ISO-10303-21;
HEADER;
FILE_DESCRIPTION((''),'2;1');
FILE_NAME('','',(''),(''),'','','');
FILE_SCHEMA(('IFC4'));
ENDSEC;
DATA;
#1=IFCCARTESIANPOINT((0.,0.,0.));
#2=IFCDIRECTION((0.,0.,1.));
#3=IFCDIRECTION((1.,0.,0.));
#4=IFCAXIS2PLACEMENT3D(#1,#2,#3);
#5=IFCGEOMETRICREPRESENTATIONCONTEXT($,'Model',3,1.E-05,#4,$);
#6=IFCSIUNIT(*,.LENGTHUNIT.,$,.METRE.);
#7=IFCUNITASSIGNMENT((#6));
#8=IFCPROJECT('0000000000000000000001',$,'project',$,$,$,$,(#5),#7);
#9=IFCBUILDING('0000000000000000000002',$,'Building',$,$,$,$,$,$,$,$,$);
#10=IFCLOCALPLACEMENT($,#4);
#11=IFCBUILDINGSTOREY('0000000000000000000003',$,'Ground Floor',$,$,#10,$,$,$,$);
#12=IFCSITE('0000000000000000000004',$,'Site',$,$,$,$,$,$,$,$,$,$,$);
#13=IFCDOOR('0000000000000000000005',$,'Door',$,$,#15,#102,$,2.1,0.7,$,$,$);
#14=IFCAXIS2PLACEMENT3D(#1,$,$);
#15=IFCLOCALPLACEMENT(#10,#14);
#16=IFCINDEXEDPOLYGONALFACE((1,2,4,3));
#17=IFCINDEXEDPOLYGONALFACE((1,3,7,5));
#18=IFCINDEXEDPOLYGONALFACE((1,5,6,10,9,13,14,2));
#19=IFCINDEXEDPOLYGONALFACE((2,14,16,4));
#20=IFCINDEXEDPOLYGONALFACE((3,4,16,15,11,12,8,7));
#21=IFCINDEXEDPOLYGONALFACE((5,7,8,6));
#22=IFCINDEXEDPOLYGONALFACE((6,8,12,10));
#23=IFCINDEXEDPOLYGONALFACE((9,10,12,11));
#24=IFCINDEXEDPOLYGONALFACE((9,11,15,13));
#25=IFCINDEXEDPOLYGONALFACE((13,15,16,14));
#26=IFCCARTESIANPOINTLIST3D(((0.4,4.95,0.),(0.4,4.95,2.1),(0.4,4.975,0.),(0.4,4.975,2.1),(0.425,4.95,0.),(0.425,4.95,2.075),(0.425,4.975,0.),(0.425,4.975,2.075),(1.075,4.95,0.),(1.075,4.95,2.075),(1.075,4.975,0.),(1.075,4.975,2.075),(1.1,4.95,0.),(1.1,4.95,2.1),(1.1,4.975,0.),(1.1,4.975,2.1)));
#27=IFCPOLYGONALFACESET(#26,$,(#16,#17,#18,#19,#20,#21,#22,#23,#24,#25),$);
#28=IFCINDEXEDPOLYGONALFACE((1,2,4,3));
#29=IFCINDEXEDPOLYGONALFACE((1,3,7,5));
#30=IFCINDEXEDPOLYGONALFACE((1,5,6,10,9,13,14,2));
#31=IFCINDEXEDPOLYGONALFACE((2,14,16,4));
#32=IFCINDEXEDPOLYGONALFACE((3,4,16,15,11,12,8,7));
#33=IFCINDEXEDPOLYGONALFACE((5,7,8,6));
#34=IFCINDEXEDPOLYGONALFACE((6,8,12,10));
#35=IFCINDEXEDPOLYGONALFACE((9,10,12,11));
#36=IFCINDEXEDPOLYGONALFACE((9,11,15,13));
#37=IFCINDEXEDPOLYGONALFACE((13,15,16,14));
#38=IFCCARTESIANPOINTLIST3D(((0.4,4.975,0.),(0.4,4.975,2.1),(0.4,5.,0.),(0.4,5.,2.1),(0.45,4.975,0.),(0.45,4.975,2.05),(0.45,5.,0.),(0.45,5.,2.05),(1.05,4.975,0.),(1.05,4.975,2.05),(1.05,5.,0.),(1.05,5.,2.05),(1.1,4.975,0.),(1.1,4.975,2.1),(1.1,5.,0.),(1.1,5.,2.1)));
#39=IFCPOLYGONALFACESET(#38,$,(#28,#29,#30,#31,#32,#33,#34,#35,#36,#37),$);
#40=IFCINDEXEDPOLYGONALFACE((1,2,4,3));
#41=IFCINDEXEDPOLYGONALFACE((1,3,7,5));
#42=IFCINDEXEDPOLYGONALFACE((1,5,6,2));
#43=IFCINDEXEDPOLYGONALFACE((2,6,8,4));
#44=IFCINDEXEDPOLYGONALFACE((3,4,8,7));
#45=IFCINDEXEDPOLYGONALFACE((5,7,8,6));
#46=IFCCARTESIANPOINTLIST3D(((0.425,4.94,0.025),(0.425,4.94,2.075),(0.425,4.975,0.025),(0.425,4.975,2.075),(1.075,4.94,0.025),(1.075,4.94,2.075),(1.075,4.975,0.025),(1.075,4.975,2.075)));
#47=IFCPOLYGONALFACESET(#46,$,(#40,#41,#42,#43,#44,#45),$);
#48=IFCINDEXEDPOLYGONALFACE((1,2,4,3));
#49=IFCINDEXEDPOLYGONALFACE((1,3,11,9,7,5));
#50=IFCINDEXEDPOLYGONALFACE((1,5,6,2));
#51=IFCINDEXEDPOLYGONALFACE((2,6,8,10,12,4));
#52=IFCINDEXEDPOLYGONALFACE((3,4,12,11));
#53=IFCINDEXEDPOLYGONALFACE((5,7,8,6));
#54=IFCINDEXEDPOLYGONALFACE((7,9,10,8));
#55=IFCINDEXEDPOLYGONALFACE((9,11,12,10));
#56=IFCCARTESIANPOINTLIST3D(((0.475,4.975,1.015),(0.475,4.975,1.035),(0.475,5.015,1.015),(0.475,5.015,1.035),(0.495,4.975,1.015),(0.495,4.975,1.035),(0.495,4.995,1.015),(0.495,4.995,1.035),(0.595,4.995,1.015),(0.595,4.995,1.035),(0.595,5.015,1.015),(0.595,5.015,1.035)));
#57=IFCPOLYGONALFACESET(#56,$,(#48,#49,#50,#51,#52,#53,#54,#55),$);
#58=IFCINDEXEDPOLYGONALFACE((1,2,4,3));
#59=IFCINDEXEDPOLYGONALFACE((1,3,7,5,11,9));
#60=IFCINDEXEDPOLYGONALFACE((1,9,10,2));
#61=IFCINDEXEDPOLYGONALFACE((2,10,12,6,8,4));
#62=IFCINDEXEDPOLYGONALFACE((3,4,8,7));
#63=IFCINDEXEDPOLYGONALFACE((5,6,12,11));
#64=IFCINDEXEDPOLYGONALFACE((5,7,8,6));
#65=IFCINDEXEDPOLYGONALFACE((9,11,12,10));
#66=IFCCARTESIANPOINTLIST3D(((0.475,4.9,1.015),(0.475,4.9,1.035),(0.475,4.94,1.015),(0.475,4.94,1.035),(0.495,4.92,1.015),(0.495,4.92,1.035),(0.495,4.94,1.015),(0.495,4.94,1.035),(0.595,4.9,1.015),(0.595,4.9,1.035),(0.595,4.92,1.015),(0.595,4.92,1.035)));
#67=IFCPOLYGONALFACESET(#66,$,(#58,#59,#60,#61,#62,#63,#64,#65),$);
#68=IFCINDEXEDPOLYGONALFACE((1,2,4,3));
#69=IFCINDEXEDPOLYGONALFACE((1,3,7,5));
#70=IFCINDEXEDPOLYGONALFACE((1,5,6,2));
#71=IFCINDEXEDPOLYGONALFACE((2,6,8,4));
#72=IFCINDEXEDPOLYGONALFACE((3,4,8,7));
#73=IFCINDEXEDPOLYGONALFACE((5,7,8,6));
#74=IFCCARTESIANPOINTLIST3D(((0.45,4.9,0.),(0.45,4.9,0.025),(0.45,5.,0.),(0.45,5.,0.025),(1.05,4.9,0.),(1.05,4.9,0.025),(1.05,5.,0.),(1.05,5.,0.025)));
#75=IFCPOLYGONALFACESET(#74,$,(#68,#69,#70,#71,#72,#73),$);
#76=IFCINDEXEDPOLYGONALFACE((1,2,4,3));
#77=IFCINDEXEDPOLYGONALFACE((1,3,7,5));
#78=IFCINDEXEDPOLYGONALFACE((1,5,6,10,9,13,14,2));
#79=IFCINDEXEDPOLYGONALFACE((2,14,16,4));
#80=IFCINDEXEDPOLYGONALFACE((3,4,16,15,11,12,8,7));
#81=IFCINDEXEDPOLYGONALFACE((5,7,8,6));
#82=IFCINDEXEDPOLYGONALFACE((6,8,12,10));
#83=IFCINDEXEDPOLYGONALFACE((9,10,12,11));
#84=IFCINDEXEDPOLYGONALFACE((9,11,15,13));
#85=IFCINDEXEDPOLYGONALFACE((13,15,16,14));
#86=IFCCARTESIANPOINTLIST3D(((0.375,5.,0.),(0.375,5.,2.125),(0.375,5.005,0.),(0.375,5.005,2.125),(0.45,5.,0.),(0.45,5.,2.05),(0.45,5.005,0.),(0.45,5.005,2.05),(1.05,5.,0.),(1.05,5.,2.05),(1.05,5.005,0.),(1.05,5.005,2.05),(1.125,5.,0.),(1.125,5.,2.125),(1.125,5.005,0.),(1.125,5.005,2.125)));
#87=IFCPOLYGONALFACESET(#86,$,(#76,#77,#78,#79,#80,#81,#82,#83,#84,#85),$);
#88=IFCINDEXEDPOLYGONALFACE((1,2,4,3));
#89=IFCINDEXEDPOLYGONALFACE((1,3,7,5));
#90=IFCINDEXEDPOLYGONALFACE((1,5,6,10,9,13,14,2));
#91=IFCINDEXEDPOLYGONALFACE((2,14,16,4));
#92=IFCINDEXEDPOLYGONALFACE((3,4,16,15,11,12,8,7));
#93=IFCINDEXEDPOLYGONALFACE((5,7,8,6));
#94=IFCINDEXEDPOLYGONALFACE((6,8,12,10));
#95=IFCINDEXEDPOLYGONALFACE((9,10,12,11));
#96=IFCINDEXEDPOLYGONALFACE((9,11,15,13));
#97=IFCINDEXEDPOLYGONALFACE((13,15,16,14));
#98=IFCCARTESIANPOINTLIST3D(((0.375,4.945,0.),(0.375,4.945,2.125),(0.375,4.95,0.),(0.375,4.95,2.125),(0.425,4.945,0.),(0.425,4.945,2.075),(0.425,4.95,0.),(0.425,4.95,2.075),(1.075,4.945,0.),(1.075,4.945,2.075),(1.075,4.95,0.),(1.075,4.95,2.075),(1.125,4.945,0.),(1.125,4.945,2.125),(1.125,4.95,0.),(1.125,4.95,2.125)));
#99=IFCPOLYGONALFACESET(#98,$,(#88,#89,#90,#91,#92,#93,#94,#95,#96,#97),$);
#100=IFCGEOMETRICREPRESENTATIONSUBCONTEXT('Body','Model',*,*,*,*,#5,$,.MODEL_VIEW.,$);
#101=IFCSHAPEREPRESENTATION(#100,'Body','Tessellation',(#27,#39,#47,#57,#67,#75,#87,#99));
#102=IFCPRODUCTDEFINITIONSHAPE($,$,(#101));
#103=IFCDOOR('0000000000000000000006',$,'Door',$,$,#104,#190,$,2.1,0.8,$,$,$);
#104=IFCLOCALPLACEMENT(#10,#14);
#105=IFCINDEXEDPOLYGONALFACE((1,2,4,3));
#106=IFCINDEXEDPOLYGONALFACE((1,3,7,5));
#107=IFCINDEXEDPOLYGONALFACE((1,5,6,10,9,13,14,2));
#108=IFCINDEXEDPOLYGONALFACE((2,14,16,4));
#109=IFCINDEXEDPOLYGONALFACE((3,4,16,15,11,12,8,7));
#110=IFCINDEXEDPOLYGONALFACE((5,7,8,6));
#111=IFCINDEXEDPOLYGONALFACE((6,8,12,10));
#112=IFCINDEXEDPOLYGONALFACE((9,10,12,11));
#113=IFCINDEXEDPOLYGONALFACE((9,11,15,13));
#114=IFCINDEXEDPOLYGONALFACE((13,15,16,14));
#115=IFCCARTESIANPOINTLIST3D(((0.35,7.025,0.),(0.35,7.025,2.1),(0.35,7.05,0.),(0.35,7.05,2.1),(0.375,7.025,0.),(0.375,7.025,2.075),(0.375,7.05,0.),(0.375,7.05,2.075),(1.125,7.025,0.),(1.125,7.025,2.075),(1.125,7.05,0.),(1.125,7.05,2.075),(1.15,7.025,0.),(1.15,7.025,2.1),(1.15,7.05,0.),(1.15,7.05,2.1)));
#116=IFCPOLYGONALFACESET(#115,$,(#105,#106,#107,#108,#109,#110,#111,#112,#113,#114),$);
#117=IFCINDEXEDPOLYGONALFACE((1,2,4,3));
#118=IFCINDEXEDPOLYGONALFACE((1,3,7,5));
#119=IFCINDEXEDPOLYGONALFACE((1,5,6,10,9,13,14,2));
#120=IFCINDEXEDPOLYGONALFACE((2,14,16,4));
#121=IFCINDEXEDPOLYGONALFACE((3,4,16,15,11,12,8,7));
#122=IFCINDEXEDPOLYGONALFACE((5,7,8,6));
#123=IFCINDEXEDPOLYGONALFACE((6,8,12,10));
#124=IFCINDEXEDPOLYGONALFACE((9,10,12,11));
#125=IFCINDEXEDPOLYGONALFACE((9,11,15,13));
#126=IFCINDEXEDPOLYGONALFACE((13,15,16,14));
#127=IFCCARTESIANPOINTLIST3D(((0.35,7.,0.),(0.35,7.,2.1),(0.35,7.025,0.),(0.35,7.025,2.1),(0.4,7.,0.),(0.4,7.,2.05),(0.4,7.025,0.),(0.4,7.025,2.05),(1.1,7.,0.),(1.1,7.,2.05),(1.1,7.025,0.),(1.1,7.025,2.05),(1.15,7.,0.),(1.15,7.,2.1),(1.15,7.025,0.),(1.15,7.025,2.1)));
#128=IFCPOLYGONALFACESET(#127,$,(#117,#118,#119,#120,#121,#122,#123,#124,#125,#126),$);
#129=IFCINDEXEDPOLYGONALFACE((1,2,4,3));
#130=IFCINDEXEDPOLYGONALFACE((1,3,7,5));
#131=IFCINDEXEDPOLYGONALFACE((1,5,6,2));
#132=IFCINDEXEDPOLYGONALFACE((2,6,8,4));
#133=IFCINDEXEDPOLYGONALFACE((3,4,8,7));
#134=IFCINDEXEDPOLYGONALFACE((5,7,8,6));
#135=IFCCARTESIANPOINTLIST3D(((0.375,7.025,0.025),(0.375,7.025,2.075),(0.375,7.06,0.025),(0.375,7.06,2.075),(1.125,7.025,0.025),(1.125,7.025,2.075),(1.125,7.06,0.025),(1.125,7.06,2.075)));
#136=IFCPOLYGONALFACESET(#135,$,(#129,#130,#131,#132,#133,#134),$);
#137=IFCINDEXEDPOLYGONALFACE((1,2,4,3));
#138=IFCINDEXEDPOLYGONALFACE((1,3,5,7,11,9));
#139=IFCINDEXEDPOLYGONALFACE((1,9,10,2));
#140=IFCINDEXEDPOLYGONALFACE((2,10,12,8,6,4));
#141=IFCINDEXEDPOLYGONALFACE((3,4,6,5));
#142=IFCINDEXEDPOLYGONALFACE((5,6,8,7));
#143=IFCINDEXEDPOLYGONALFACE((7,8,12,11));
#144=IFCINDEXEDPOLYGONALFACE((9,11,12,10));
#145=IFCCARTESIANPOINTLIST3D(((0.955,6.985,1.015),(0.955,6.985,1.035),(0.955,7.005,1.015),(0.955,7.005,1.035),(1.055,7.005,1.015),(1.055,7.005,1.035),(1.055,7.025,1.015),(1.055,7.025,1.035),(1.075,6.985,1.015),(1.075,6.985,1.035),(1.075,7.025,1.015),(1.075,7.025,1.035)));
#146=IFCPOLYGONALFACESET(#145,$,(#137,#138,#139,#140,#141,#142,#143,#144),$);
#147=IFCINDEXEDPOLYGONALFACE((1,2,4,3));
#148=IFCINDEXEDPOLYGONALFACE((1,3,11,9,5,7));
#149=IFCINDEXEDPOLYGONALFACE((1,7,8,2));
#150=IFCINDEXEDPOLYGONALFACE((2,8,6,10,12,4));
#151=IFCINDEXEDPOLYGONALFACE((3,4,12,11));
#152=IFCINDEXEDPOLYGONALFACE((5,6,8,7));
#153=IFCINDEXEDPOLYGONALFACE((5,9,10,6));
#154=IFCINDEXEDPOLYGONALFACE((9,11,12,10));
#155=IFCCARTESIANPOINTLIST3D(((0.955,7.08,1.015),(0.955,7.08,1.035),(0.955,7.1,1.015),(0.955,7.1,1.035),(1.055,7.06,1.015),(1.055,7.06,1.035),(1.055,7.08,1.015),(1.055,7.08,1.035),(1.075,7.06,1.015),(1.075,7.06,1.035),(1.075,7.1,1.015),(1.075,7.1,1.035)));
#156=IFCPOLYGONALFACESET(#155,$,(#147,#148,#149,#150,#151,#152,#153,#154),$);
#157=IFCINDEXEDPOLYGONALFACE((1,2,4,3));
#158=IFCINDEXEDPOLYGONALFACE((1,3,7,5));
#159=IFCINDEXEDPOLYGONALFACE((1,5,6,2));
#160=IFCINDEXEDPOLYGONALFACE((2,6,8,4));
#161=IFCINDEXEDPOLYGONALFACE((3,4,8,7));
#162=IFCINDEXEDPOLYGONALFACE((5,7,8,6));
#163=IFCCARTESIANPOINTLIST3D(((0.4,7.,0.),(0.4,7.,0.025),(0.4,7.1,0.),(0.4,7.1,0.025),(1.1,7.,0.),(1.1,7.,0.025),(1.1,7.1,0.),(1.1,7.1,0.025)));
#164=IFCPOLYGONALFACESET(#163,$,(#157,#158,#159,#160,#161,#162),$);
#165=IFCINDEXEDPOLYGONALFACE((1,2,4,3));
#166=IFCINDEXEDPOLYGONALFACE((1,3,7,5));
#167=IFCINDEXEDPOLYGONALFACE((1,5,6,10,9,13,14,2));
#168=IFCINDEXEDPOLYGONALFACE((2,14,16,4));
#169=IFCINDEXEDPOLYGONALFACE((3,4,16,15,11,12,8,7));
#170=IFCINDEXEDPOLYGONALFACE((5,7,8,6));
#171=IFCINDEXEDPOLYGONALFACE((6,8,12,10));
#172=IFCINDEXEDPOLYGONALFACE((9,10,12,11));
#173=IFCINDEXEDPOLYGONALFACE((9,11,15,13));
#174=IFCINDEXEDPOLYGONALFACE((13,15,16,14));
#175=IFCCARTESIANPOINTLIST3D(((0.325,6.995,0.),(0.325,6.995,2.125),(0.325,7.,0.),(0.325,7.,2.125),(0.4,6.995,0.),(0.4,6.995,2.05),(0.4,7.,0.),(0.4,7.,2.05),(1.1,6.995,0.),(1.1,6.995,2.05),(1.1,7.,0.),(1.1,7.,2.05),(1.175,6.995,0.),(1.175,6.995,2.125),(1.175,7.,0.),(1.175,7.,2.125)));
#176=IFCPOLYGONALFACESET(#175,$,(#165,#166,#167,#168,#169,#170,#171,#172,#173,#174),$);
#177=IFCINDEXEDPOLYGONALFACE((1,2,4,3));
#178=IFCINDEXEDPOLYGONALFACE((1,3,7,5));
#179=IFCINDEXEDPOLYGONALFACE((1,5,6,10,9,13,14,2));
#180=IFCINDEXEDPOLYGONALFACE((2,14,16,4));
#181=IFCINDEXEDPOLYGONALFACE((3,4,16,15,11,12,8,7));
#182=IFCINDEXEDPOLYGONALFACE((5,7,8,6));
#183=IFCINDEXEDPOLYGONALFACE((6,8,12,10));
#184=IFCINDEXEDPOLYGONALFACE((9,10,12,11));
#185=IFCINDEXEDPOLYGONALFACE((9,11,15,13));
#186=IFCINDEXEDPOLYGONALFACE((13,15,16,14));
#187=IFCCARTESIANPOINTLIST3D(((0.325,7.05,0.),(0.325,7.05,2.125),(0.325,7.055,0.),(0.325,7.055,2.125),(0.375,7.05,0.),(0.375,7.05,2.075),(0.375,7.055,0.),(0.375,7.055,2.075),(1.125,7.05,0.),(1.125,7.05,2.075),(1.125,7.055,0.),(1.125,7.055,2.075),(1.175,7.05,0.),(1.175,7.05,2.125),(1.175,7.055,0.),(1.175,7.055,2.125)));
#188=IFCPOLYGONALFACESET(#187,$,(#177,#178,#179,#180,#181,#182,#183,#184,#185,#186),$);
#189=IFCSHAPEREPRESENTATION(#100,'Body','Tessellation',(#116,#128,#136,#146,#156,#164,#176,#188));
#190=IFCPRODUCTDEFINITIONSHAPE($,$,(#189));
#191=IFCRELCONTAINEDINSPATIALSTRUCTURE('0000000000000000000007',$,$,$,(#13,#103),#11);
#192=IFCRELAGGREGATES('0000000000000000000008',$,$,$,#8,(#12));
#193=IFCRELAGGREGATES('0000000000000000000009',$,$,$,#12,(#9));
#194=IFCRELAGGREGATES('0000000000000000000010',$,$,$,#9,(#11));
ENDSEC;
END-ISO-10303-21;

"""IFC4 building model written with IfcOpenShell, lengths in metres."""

from ifc_helpers import new_model, si_unit, frame, origin_with_axes, place, context, subcontext, project, spatial, line, indexed_curve, outline, extrude, element, save


model = new_model("IFC4")

# Units and contexts
model_context = context("Model", 3, precision=1e-05, world=origin_with_axes())
body_context = subcontext(model_context, "Body", "Model", "MODEL_VIEW")
ifc_project = project(units=[si_unit("LENGTHUNIT", "METRE")], contexts=[model_context])

# Site, building, storey
site = spatial("IfcSite", under=ifc_project, Name="Site")
building = spatial("IfcBuilding", under=site, Name="Building")
storey_placement = place(None, origin_with_axes())
storey = spatial("IfcBuildingStorey", under=building, at=storey_placement, Name="Ground Floor")

# Doors
door_1_placement = place(storey_placement, frame((1.1, 5.0, 0.0), z_axis=(0.0, 0.0, 1.0), x_axis=(-1.0, 0.0, 0.0)))
element("IfcDoor", 1, at=door_1_placement, inside=storey, Name="Door", OverallHeight=2.1, OverallWidth=0.7, context=body_context, shape_type="SweptSolid", body=[
    extrude(outline(indexed_curve([(0.0, 0.0), (0.0, 2.1), (0.7, 2.1), (0.7, 0.0), (0.675, 0.0), (0.675, 2.075), (0.025, 2.075), (0.025, 0.0)], segments=[line(1, 2, 3, 4, 5, 6, 7, 8, 1)])), frame((0.0, 0.025, 0.0), z_axis=(0.0, -1.0, 0.0), x_axis=(1.0, 0.0, 0.0)), (0.0, 0.0, -1.0), 0.025),
    extrude(outline(indexed_curve([(0.0, 0.0), (0.0, 2.1), (0.7, 2.1), (0.7, 0.0), (0.65, 0.0), (0.65, 2.05), (0.05, 2.05), (0.05, 0.0)], segments=[line(1, 2, 3, 4, 5, 6, 7, 8, 1)])), frame((0.0, 0.0, 0.0), z_axis=(0.0, -1.0, 0.0), x_axis=(1.0, 0.0, 0.0)), (0.0, 0.0, -1.0), 0.025),
    extrude(outline(indexed_curve([(0.0, 0.0), (0.65, 0.0), (0.65, 0.035), (0.0, 0.035)], segments=[line(1, 2, 3, 4, 1)])), frame((0.025, 0.025, 0.025), z_axis=(0.0, 0.0, 1.0), x_axis=(1.0, 0.0, 0.0)), (0.0, 0.0, 1.0), 2.05),
    extrude(outline(indexed_curve([(0.0, 0.0), (0.0, -0.04), (-0.12, -0.04), (-0.12, -0.02), (-0.02, -0.02), (-0.02, 0.0)], segments=[line(1, 2, 3, 4, 5, 6, 1)])), frame((0.625, 0.025, 1.015), z_axis=(0.0, 0.0, 1.0), x_axis=(1.0, 0.0, 0.0)), (0.0, 0.0, 1.0), 0.02),
    extrude(outline(indexed_curve([(0.0, 0.0), (0.0, 0.04), (-0.12, 0.04), (-0.12, 0.02), (-0.02, 0.02), (-0.02, 0.0)], segments=[line(1, 2, 3, 4, 5, 6, 1)])), frame((0.625, 0.06, 1.015), z_axis=(0.0, 0.0, 1.0), x_axis=(1.0, 0.0, 0.0)), (0.0, 0.0, 1.0), 0.02),
    extrude(outline(indexed_curve([(0.0, 0.0), (0.6, 0.0), (0.6, 0.1), (0.0, 0.1)], segments=[line(1, 2, 3, 4, 1)])), frame((0.05, 0.0, 0.0), z_axis=(0.0, 0.0, 1.0), x_axis=(1.0, 0.0, 0.0)), (0.0, 0.0, 1.0), 0.025),
    extrude(outline(indexed_curve([(0.0, 0.0), (0.0, 2.125), (0.75, 2.125), (0.75, 0.0), (0.675, 0.0), (0.675, 2.05), (0.075, 2.05), (0.075, 0.0)], segments=[line(1, 2, 3, 4, 5, 6, 7, 8, 1)])), frame((-0.025, -0.005, 0.0), z_axis=(0.0, -1.0, 0.0), x_axis=(1.0, 0.0, 0.0)), (0.0, 0.0, -1.0), 0.005),
    extrude(outline(indexed_curve([(0.0, 0.0), (0.0, 2.125), (0.75, 2.125), (0.75, 0.0), (0.7, 0.0), (0.7, 2.075), (0.05, 2.075), (0.05, 0.0)], segments=[line(1, 2, 3, 4, 5, 6, 7, 8, 1)])), frame((-0.025, 0.05, 0.0), z_axis=(0.0, -1.0, 0.0), x_axis=(1.0, 0.0, 0.0)), (0.0, 0.0, -1.0), 0.005),
])
door_2_placement = place(storey_placement, frame((0.35, 7.0, 0.0), z_axis=(0.0, 0.0, 1.0), x_axis=(1.0, 0.0, 0.0)))
element("IfcDoor", 2, at=door_2_placement, inside=storey, Name="Door", OverallHeight=2.1, OverallWidth=0.8, context=body_context, shape_type="SweptSolid", body=[
    extrude(outline(indexed_curve([(0.0, 0.0), (0.0, 2.1), (0.8, 2.1), (0.8, 0.0), (0.775, 0.0), (0.775, 2.075), (0.025, 2.075), (0.025, 0.0)], segments=[line(1, 2, 3, 4, 5, 6, 7, 8, 1)])), frame((0.0, 0.025, 0.0), z_axis=(0.0, -1.0, 0.0), x_axis=(1.0, 0.0, 0.0)), (0.0, 0.0, -1.0), 0.025),
    extrude(outline(indexed_curve([(0.0, 0.0), (0.0, 2.1), (0.8, 2.1), (0.8, 0.0), (0.75, 0.0), (0.75, 2.05), (0.05, 2.05), (0.05, 0.0)], segments=[line(1, 2, 3, 4, 5, 6, 7, 8, 1)])), frame((0.0, 0.0, 0.0), z_axis=(0.0, -1.0, 0.0), x_axis=(1.0, 0.0, 0.0)), (0.0, 0.0, -1.0), 0.025),
    extrude(outline(indexed_curve([(0.0, 0.0), (0.75, 0.0), (0.75, 0.035), (0.0, 0.035)], segments=[line(1, 2, 3, 4, 1)])), frame((0.025, 0.025, 0.025), z_axis=(0.0, 0.0, 1.0), x_axis=(1.0, 0.0, 0.0)), (0.0, 0.0, 1.0), 2.05),
    extrude(outline(indexed_curve([(0.0, 0.0), (0.0, -0.04), (-0.12, -0.04), (-0.12, -0.02), (-0.02, -0.02), (-0.02, 0.0)], segments=[line(1, 2, 3, 4, 5, 6, 1)])), frame((0.725, 0.025, 1.015), z_axis=(0.0, 0.0, 1.0), x_axis=(1.0, 0.0, 0.0)), (0.0, 0.0, 1.0), 0.02),
    extrude(outline(indexed_curve([(0.0, 0.0), (0.0, 0.04), (-0.12, 0.04), (-0.12, 0.02), (-0.02, 0.02), (-0.02, 0.0)], segments=[line(1, 2, 3, 4, 5, 6, 1)])), frame((0.725, 0.06, 1.015), z_axis=(0.0, 0.0, 1.0), x_axis=(1.0, 0.0, 0.0)), (0.0, 0.0, 1.0), 0.02),
    extrude(outline(indexed_curve([(0.0, 0.0), (0.7, 0.0), (0.7, 0.1), (0.0, 0.1)], segments=[line(1, 2, 3, 4, 1)])), frame((0.05, 0.0, 0.0), z_axis=(0.0, 0.0, 1.0), x_axis=(1.0, 0.0, 0.0)), (0.0, 0.0, 1.0), 0.025),
    extrude(outline(indexed_curve([(0.0, 0.0), (0.0, 2.125), (0.85, 2.125), (0.85, 0.0), (0.775, 0.0), (0.775, 2.05), (0.075, 2.05), (0.075, 0.0)], segments=[line(1, 2, 3, 4, 5, 6, 7, 8, 1)])), frame((-0.025, -0.005, 0.0), z_axis=(0.0, -1.0, 0.0), x_axis=(1.0, 0.0, 0.0)), (0.0, 0.0, -1.0), 0.005),
    extrude(outline(indexed_curve([(0.0, 0.0), (0.0, 2.125), (0.85, 2.125), (0.85, 0.0), (0.8, 0.0), (0.8, 2.075), (0.05, 2.075), (0.05, 0.0)], segments=[line(1, 2, 3, 4, 5, 6, 7, 8, 1)])), frame((-0.025, 0.05, 0.0), z_axis=(0.0, -1.0, 0.0), x_axis=(1.0, 0.0, 0.0)), (0.0, 0.0, -1.0), 0.005),
])

save(model, "model.ifc")
